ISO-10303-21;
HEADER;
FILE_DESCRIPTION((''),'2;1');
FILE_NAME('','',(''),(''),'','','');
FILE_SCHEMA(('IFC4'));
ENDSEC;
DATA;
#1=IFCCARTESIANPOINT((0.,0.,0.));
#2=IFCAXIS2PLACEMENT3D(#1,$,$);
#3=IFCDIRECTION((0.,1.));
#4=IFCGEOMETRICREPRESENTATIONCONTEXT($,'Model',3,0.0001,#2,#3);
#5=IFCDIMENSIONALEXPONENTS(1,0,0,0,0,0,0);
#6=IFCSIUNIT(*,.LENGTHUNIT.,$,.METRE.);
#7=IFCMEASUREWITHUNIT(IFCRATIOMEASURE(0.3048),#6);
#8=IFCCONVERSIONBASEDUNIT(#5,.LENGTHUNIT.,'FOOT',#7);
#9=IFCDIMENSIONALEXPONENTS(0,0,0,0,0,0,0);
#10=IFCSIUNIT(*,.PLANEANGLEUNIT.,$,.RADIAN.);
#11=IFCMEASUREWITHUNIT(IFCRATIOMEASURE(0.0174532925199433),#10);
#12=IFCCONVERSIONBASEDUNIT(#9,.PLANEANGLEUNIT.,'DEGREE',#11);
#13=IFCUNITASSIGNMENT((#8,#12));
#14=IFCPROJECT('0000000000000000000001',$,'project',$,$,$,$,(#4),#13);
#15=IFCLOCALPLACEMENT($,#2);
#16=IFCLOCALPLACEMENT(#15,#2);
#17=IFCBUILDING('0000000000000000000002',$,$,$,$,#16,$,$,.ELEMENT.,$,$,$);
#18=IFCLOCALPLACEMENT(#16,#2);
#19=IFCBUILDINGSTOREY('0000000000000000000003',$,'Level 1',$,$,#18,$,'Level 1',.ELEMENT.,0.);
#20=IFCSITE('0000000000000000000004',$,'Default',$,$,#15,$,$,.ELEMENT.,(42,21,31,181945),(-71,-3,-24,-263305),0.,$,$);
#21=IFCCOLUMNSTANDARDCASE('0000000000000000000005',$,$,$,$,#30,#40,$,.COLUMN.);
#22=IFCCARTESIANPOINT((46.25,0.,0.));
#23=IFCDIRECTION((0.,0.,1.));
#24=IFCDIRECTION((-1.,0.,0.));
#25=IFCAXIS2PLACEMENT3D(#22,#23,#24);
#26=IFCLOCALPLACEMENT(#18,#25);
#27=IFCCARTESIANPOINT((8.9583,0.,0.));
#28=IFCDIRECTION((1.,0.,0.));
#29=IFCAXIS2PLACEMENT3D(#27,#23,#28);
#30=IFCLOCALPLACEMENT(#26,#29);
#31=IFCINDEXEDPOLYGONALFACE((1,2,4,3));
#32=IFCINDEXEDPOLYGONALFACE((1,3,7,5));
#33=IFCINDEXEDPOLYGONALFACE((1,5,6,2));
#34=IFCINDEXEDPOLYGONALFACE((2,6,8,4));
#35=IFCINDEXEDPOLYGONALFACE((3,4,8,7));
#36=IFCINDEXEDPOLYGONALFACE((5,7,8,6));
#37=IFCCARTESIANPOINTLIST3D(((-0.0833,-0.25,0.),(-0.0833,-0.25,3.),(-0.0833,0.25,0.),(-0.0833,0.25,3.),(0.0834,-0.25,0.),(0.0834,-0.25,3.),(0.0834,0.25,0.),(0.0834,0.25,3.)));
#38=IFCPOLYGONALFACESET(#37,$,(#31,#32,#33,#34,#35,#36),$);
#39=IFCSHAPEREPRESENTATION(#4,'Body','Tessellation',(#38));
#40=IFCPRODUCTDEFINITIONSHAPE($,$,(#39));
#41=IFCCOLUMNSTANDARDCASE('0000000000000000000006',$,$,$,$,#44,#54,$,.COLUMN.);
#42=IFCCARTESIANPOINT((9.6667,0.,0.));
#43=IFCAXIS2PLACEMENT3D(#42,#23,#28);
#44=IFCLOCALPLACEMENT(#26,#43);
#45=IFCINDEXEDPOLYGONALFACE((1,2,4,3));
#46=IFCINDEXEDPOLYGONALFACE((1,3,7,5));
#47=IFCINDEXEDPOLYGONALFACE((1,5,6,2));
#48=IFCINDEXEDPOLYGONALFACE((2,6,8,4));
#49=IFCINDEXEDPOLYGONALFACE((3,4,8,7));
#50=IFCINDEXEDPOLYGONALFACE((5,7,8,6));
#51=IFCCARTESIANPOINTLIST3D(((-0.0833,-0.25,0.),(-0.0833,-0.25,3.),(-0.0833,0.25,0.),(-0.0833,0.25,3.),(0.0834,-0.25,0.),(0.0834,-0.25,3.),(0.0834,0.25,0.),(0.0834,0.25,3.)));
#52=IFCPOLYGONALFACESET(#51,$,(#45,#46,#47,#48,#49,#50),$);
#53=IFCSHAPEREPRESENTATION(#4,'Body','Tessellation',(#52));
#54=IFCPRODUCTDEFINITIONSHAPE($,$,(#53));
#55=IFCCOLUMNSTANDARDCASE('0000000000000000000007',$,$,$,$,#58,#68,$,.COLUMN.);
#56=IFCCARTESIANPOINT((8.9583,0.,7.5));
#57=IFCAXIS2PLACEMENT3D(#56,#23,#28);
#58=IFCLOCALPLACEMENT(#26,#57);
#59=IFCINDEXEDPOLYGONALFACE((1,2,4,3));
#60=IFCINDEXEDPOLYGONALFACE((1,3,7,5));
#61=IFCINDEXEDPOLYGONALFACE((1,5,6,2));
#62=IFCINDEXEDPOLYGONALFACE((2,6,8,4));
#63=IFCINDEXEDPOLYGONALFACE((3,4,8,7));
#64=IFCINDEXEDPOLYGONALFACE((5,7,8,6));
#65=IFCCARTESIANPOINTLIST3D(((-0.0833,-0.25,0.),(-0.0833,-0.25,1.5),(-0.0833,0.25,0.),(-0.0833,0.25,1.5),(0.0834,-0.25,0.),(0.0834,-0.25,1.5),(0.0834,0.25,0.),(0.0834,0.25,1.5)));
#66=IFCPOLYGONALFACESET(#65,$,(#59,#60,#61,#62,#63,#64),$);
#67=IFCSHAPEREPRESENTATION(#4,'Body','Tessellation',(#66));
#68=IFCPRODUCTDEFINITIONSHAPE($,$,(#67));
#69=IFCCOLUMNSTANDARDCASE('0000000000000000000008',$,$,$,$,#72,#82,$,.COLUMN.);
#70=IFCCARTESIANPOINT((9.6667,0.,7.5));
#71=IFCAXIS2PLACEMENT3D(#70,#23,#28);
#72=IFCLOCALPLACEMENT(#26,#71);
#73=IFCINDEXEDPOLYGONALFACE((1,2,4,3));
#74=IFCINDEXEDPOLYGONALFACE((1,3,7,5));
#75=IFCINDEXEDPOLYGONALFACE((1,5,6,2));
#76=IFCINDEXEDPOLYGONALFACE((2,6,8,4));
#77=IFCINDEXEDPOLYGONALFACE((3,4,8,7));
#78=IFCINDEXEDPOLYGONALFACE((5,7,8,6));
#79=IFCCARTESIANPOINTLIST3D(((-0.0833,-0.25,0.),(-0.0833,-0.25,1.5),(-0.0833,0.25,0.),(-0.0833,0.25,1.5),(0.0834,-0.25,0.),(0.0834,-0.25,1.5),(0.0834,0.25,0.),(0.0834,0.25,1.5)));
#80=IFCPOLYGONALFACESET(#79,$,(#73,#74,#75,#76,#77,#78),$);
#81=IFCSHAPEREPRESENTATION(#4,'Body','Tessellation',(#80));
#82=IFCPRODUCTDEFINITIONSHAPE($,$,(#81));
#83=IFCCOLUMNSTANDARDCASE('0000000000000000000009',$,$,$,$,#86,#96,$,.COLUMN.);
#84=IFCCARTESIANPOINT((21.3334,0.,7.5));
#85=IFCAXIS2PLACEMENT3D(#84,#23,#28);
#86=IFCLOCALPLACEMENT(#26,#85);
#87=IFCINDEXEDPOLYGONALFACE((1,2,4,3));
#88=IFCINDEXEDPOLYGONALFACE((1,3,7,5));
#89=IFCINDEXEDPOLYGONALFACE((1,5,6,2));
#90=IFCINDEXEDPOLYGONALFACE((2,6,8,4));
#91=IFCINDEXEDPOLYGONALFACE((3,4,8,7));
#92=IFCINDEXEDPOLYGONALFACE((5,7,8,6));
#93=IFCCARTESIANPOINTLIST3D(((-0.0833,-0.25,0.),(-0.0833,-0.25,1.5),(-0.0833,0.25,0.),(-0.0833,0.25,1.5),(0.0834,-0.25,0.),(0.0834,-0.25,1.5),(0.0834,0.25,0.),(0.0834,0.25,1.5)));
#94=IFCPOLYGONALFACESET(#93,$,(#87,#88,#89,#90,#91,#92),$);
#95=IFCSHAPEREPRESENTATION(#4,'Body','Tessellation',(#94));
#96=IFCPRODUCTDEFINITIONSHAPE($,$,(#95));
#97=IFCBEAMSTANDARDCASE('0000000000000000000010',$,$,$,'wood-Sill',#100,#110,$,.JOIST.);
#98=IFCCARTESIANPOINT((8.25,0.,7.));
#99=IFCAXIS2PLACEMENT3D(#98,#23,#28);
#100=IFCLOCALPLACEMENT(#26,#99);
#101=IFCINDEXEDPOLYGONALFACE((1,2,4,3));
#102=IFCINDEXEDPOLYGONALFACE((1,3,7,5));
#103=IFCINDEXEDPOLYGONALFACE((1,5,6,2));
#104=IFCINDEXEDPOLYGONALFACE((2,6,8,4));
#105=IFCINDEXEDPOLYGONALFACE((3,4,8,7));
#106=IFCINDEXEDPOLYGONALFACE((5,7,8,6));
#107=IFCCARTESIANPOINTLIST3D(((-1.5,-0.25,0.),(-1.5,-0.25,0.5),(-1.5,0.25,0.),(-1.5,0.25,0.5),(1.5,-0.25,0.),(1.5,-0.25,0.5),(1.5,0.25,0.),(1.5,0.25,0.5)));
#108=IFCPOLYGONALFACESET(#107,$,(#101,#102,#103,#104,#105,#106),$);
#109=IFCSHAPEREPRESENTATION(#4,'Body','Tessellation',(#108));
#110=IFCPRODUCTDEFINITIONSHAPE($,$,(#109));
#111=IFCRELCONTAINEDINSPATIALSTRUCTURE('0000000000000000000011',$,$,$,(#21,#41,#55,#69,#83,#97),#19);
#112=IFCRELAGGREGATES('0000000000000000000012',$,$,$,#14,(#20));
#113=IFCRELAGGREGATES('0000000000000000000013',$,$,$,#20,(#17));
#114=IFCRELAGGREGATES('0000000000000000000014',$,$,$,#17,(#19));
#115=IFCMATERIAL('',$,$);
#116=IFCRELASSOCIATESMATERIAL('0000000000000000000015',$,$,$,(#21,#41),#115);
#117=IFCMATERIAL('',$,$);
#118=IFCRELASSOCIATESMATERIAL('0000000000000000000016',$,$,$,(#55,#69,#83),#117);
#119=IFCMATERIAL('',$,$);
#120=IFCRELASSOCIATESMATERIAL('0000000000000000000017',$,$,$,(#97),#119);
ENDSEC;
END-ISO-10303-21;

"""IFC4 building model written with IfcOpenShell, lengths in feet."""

from ifc_helpers import new_model, entity, si_unit, converted_unit, direction, frame, origin, place, context, project, spatial, rectangle, extrude, material, element, save


model = new_model("IFC4")

# Units and contexts
model_context = context("Model", 3, precision=0.0001, world=origin(), true_north=direction((0.0, 1.0)))
ifc_project = project(units=[converted_unit("LENGTHUNIT", "FOOT", entity("IfcRatioMeasure", 0.3048), si_unit("LENGTHUNIT", "METRE"), dimensions=[1, 0, 0, 0, 0, 0, 0]), converted_unit("PLANEANGLEUNIT", "DEGREE", entity("IfcRatioMeasure", 0.0174532925199433), si_unit("PLANEANGLEUNIT", "RADIAN"), dimensions=[0, 0, 0, 0, 0, 0, 0])], contexts=[model_context])

# Site, building, storey
site_placement = place(None, origin())
site = spatial("IfcSite", under=ifc_project, at=site_placement, Name="Default", CompositionType="ELEMENT", RefLatitude=(42, 21, 31, 181945), RefLongitude=(-71, -3, -24, -263305), RefElevation=0.0)
building_placement = place(site_placement, origin())
building = spatial("IfcBuilding", under=site, at=building_placement, CompositionType="ELEMENT")
storey_placement = place(building_placement, origin())
storey = spatial("IfcBuildingStorey", under=building, at=storey_placement, Name="Level 1", LongName="Level 1", CompositionType="ELEMENT", Elevation=0.0)

# Columns
placement = place(storey_placement, frame((46.25, 0.0, 0.0), z_axis=(0.0, 0.0, 1.0), x_axis=(-1.0, 0.0, 0.0)))
ifc_material_1 = material(Name="")
for number, where, z_axis, x_axis in (
    (1, (8.9583, 0.0, 0.0), (0.0, 0.0, 1.0), (1.0, 0.0, 0.0)),
    (2, (9.6667, 0.0, 0.0), (0.0, 0.0, 1.0), (1.0, 0.0, 0.0)),
):
    element("IfcColumnStandardCase", number, at=place(placement, frame(where, z_axis=z_axis, x_axis=x_axis)), inside=storey, material=ifc_material_1, PredefinedType="COLUMN", context=model_context, shape_type="SweptSolid", body=[
        extrude(rectangle(XDim=0.1667, YDim=0.5), origin(), (0.0, 0.0, 1.0), 3.0),
    ])
ifc_material_2 = material(Name="")
for number, where, z_axis, x_axis in (
    (3, (8.9583, 0.0, 7.5), (0.0, 0.0, 1.0), (1.0, 0.0, 0.0)),
    (4, (9.6667, 0.0, 7.5), (0.0, 0.0, 1.0), (1.0, 0.0, 0.0)),
    (5, (21.3334, 0.0, 7.5), (0.0, 0.0, 1.0), (1.0, 0.0, 0.0)),
):
    element("IfcColumnStandardCase", number, at=place(placement, frame(where, z_axis=z_axis, x_axis=x_axis)), inside=storey, material=ifc_material_2, PredefinedType="COLUMN", context=model_context, shape_type="SweptSolid", body=[
        extrude(rectangle(XDim=0.1667, YDim=0.5), origin(), (0.0, 0.0, 1.0), 1.5),
    ])

# Beam
ifc_material_3 = material(Name="")
beam_placement = place(placement, frame((8.25, 0.0, 7.0), z_axis=(0.0, 0.0, 1.0), x_axis=(1.0, 0.0, 0.0)))
element("IfcBeamStandardCase", 6, at=beam_placement, inside=storey, material=ifc_material_3, ObjectType="wood-Sill", PredefinedType="JOIST", context=model_context, shape_type="SweptSolid", body=[
    extrude(rectangle(XDim=3.0, YDim=0.5), origin(), (0.0, 0.0, 1.0), 0.5),
])

save(model, "model.ifc")
